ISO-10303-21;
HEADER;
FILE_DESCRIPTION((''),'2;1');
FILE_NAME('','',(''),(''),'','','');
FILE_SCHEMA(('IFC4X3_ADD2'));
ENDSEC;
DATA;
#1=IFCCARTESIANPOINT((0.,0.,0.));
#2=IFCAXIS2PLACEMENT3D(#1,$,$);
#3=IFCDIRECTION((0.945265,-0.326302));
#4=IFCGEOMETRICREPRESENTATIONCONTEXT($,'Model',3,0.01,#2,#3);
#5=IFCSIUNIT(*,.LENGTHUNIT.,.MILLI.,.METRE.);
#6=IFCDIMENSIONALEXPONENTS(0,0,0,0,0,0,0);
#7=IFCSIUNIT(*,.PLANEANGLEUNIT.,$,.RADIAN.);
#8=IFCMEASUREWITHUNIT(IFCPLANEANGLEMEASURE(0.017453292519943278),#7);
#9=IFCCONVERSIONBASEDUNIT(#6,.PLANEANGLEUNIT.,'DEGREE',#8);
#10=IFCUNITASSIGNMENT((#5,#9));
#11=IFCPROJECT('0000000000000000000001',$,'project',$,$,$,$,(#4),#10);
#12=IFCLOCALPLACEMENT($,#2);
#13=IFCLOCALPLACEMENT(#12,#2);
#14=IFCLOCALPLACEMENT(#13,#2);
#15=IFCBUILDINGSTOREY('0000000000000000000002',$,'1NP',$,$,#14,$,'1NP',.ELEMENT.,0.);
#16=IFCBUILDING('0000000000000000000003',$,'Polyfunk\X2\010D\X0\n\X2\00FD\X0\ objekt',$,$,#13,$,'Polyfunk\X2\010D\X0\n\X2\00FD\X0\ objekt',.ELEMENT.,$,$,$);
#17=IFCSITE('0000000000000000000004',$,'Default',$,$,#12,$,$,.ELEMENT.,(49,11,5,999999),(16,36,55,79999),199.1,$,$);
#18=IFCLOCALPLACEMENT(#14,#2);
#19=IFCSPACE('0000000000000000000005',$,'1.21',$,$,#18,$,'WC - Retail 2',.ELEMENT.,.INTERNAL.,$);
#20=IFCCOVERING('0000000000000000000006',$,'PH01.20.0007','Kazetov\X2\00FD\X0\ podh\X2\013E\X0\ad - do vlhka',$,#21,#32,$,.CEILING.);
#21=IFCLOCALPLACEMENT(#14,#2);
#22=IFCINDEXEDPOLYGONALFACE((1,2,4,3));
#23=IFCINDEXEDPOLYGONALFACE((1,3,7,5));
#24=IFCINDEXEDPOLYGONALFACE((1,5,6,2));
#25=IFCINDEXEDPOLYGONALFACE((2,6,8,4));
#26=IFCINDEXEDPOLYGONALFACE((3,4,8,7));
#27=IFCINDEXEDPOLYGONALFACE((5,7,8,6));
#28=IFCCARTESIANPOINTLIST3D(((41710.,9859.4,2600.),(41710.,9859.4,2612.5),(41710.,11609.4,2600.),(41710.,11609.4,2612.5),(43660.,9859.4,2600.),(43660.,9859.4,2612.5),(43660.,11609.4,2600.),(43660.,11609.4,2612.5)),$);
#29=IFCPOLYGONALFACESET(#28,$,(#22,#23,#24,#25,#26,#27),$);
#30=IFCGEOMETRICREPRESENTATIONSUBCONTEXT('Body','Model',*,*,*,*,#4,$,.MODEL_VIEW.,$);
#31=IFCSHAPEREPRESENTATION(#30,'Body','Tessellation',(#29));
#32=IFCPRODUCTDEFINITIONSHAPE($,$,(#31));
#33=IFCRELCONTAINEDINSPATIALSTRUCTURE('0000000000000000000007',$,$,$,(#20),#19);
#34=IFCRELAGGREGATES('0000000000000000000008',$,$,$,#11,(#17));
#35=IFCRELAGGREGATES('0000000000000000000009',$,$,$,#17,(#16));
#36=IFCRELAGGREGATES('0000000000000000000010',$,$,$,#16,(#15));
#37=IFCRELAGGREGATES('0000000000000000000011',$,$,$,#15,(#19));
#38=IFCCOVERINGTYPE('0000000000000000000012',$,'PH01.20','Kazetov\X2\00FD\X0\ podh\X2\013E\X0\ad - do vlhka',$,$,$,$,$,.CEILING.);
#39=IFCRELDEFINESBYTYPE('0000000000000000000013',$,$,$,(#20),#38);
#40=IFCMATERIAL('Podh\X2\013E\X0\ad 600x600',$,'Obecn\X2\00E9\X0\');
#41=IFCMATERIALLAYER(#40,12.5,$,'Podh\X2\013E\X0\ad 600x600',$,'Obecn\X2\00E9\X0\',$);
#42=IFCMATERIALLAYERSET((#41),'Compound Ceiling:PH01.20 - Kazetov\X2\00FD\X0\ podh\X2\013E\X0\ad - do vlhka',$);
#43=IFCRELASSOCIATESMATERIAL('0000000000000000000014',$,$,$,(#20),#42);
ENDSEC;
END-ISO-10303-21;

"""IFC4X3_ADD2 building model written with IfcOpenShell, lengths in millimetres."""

from ifc_helpers import new_model, entity, si_unit, converted_unit, direction, frame, frame_2d, origin, place, context, subcontext, project, spatial, rectangle, extrude, material, layer, layer_set, layer_usage, type_object, element, save


model = new_model("IFC4X3_ADD2")

# Units and contexts
model_context = context("Model", 3, precision=0.01, world=origin(), true_north=direction((0.945265, -0.326302)))
body_context = subcontext(model_context, "Body", "Model", "MODEL_VIEW")
ifc_project = project(units=[si_unit("LENGTHUNIT", "METRE", prefix="MILLI"), converted_unit("PLANEANGLEUNIT", "DEGREE", entity("IfcPlaneAngleMeasure", 0.017453292519943278), si_unit("PLANEANGLEUNIT", "RADIAN"), dimensions=[0, 0, 0, 0, 0, 0, 0])], contexts=[model_context])

# Site, building, storey
site_placement = place(None, origin())
site = spatial("IfcSite", under=ifc_project, at=site_placement, Name="Default", CompositionType="ELEMENT", RefLatitude=(49, 11, 5, 999999), RefLongitude=(16, 36, 55, 79999), RefElevation=199.1)
building_placement = place(site_placement, origin())
building = spatial("IfcBuilding", under=site, at=building_placement, Name="Polyfunkčný objekt", LongName="Polyfunkčný objekt", CompositionType="ELEMENT")
storey_placement = place(building_placement, origin())
storey = spatial("IfcBuildingStorey", under=building, at=storey_placement, Name="1NP", LongName="1NP", CompositionType="ELEMENT", Elevation=0.0)

# Shared definitions
ifc_material_1 = material(Name="Podhľad 600x600", Category="Obecné")

# Shared definitions
space_1_placement = place(storey_placement, origin())
space_1 = spatial("IfcSpace", under=storey, at=space_1_placement, Name="1.21", LongName="WC - Retail 2", CompositionType="ELEMENT", PredefinedType="INTERNAL")

# Covering
ifc_layer_1 = layer(ifc_material_1, 12.5, Name="Podhľad 600x600", Category="Obecné")
ifc_layer_set_1 = layer_set([ifc_layer_1], Name="Compound Ceiling:PH01.20 - Kazetový podhľad - do vlhka")
ifc_layer_usage_1 = layer_usage(ifc_layer_set_1, "AXIS3", "NEGATIVE", 0.0)
covering_type_1 = type_object("IfcCoveringType", Name="PH01.20", Description="Kazetový podhľad - do vlhka", PredefinedType="CEILING")
covering_1_placement = place(storey_placement, frame((41710.0, 9859.4, 2600.0)))
element("IfcCovering", 1, at=covering_1_placement, inside=space_1, type_object=covering_type_1, material=ifc_layer_usage_1, Name="PH01.20.0007", Description="Kazetový podhľad - do vlhka", PredefinedType="CEILING", context=body_context, shape_type="SweptSolid", body=[
    extrude(rectangle(XDim=1950.0, YDim=1750.0, at=frame_2d((0.0, 0.0), x_axis=(1.0, 0.0))), frame((975.0, 875.0, 0.0), z_axis=(0.0, 0.0, 1.0), x_axis=(-1.0, 0.0, 0.0)), (0.0, 0.0, 1.0), 12.5),
])

save(model, "model.ifc")
